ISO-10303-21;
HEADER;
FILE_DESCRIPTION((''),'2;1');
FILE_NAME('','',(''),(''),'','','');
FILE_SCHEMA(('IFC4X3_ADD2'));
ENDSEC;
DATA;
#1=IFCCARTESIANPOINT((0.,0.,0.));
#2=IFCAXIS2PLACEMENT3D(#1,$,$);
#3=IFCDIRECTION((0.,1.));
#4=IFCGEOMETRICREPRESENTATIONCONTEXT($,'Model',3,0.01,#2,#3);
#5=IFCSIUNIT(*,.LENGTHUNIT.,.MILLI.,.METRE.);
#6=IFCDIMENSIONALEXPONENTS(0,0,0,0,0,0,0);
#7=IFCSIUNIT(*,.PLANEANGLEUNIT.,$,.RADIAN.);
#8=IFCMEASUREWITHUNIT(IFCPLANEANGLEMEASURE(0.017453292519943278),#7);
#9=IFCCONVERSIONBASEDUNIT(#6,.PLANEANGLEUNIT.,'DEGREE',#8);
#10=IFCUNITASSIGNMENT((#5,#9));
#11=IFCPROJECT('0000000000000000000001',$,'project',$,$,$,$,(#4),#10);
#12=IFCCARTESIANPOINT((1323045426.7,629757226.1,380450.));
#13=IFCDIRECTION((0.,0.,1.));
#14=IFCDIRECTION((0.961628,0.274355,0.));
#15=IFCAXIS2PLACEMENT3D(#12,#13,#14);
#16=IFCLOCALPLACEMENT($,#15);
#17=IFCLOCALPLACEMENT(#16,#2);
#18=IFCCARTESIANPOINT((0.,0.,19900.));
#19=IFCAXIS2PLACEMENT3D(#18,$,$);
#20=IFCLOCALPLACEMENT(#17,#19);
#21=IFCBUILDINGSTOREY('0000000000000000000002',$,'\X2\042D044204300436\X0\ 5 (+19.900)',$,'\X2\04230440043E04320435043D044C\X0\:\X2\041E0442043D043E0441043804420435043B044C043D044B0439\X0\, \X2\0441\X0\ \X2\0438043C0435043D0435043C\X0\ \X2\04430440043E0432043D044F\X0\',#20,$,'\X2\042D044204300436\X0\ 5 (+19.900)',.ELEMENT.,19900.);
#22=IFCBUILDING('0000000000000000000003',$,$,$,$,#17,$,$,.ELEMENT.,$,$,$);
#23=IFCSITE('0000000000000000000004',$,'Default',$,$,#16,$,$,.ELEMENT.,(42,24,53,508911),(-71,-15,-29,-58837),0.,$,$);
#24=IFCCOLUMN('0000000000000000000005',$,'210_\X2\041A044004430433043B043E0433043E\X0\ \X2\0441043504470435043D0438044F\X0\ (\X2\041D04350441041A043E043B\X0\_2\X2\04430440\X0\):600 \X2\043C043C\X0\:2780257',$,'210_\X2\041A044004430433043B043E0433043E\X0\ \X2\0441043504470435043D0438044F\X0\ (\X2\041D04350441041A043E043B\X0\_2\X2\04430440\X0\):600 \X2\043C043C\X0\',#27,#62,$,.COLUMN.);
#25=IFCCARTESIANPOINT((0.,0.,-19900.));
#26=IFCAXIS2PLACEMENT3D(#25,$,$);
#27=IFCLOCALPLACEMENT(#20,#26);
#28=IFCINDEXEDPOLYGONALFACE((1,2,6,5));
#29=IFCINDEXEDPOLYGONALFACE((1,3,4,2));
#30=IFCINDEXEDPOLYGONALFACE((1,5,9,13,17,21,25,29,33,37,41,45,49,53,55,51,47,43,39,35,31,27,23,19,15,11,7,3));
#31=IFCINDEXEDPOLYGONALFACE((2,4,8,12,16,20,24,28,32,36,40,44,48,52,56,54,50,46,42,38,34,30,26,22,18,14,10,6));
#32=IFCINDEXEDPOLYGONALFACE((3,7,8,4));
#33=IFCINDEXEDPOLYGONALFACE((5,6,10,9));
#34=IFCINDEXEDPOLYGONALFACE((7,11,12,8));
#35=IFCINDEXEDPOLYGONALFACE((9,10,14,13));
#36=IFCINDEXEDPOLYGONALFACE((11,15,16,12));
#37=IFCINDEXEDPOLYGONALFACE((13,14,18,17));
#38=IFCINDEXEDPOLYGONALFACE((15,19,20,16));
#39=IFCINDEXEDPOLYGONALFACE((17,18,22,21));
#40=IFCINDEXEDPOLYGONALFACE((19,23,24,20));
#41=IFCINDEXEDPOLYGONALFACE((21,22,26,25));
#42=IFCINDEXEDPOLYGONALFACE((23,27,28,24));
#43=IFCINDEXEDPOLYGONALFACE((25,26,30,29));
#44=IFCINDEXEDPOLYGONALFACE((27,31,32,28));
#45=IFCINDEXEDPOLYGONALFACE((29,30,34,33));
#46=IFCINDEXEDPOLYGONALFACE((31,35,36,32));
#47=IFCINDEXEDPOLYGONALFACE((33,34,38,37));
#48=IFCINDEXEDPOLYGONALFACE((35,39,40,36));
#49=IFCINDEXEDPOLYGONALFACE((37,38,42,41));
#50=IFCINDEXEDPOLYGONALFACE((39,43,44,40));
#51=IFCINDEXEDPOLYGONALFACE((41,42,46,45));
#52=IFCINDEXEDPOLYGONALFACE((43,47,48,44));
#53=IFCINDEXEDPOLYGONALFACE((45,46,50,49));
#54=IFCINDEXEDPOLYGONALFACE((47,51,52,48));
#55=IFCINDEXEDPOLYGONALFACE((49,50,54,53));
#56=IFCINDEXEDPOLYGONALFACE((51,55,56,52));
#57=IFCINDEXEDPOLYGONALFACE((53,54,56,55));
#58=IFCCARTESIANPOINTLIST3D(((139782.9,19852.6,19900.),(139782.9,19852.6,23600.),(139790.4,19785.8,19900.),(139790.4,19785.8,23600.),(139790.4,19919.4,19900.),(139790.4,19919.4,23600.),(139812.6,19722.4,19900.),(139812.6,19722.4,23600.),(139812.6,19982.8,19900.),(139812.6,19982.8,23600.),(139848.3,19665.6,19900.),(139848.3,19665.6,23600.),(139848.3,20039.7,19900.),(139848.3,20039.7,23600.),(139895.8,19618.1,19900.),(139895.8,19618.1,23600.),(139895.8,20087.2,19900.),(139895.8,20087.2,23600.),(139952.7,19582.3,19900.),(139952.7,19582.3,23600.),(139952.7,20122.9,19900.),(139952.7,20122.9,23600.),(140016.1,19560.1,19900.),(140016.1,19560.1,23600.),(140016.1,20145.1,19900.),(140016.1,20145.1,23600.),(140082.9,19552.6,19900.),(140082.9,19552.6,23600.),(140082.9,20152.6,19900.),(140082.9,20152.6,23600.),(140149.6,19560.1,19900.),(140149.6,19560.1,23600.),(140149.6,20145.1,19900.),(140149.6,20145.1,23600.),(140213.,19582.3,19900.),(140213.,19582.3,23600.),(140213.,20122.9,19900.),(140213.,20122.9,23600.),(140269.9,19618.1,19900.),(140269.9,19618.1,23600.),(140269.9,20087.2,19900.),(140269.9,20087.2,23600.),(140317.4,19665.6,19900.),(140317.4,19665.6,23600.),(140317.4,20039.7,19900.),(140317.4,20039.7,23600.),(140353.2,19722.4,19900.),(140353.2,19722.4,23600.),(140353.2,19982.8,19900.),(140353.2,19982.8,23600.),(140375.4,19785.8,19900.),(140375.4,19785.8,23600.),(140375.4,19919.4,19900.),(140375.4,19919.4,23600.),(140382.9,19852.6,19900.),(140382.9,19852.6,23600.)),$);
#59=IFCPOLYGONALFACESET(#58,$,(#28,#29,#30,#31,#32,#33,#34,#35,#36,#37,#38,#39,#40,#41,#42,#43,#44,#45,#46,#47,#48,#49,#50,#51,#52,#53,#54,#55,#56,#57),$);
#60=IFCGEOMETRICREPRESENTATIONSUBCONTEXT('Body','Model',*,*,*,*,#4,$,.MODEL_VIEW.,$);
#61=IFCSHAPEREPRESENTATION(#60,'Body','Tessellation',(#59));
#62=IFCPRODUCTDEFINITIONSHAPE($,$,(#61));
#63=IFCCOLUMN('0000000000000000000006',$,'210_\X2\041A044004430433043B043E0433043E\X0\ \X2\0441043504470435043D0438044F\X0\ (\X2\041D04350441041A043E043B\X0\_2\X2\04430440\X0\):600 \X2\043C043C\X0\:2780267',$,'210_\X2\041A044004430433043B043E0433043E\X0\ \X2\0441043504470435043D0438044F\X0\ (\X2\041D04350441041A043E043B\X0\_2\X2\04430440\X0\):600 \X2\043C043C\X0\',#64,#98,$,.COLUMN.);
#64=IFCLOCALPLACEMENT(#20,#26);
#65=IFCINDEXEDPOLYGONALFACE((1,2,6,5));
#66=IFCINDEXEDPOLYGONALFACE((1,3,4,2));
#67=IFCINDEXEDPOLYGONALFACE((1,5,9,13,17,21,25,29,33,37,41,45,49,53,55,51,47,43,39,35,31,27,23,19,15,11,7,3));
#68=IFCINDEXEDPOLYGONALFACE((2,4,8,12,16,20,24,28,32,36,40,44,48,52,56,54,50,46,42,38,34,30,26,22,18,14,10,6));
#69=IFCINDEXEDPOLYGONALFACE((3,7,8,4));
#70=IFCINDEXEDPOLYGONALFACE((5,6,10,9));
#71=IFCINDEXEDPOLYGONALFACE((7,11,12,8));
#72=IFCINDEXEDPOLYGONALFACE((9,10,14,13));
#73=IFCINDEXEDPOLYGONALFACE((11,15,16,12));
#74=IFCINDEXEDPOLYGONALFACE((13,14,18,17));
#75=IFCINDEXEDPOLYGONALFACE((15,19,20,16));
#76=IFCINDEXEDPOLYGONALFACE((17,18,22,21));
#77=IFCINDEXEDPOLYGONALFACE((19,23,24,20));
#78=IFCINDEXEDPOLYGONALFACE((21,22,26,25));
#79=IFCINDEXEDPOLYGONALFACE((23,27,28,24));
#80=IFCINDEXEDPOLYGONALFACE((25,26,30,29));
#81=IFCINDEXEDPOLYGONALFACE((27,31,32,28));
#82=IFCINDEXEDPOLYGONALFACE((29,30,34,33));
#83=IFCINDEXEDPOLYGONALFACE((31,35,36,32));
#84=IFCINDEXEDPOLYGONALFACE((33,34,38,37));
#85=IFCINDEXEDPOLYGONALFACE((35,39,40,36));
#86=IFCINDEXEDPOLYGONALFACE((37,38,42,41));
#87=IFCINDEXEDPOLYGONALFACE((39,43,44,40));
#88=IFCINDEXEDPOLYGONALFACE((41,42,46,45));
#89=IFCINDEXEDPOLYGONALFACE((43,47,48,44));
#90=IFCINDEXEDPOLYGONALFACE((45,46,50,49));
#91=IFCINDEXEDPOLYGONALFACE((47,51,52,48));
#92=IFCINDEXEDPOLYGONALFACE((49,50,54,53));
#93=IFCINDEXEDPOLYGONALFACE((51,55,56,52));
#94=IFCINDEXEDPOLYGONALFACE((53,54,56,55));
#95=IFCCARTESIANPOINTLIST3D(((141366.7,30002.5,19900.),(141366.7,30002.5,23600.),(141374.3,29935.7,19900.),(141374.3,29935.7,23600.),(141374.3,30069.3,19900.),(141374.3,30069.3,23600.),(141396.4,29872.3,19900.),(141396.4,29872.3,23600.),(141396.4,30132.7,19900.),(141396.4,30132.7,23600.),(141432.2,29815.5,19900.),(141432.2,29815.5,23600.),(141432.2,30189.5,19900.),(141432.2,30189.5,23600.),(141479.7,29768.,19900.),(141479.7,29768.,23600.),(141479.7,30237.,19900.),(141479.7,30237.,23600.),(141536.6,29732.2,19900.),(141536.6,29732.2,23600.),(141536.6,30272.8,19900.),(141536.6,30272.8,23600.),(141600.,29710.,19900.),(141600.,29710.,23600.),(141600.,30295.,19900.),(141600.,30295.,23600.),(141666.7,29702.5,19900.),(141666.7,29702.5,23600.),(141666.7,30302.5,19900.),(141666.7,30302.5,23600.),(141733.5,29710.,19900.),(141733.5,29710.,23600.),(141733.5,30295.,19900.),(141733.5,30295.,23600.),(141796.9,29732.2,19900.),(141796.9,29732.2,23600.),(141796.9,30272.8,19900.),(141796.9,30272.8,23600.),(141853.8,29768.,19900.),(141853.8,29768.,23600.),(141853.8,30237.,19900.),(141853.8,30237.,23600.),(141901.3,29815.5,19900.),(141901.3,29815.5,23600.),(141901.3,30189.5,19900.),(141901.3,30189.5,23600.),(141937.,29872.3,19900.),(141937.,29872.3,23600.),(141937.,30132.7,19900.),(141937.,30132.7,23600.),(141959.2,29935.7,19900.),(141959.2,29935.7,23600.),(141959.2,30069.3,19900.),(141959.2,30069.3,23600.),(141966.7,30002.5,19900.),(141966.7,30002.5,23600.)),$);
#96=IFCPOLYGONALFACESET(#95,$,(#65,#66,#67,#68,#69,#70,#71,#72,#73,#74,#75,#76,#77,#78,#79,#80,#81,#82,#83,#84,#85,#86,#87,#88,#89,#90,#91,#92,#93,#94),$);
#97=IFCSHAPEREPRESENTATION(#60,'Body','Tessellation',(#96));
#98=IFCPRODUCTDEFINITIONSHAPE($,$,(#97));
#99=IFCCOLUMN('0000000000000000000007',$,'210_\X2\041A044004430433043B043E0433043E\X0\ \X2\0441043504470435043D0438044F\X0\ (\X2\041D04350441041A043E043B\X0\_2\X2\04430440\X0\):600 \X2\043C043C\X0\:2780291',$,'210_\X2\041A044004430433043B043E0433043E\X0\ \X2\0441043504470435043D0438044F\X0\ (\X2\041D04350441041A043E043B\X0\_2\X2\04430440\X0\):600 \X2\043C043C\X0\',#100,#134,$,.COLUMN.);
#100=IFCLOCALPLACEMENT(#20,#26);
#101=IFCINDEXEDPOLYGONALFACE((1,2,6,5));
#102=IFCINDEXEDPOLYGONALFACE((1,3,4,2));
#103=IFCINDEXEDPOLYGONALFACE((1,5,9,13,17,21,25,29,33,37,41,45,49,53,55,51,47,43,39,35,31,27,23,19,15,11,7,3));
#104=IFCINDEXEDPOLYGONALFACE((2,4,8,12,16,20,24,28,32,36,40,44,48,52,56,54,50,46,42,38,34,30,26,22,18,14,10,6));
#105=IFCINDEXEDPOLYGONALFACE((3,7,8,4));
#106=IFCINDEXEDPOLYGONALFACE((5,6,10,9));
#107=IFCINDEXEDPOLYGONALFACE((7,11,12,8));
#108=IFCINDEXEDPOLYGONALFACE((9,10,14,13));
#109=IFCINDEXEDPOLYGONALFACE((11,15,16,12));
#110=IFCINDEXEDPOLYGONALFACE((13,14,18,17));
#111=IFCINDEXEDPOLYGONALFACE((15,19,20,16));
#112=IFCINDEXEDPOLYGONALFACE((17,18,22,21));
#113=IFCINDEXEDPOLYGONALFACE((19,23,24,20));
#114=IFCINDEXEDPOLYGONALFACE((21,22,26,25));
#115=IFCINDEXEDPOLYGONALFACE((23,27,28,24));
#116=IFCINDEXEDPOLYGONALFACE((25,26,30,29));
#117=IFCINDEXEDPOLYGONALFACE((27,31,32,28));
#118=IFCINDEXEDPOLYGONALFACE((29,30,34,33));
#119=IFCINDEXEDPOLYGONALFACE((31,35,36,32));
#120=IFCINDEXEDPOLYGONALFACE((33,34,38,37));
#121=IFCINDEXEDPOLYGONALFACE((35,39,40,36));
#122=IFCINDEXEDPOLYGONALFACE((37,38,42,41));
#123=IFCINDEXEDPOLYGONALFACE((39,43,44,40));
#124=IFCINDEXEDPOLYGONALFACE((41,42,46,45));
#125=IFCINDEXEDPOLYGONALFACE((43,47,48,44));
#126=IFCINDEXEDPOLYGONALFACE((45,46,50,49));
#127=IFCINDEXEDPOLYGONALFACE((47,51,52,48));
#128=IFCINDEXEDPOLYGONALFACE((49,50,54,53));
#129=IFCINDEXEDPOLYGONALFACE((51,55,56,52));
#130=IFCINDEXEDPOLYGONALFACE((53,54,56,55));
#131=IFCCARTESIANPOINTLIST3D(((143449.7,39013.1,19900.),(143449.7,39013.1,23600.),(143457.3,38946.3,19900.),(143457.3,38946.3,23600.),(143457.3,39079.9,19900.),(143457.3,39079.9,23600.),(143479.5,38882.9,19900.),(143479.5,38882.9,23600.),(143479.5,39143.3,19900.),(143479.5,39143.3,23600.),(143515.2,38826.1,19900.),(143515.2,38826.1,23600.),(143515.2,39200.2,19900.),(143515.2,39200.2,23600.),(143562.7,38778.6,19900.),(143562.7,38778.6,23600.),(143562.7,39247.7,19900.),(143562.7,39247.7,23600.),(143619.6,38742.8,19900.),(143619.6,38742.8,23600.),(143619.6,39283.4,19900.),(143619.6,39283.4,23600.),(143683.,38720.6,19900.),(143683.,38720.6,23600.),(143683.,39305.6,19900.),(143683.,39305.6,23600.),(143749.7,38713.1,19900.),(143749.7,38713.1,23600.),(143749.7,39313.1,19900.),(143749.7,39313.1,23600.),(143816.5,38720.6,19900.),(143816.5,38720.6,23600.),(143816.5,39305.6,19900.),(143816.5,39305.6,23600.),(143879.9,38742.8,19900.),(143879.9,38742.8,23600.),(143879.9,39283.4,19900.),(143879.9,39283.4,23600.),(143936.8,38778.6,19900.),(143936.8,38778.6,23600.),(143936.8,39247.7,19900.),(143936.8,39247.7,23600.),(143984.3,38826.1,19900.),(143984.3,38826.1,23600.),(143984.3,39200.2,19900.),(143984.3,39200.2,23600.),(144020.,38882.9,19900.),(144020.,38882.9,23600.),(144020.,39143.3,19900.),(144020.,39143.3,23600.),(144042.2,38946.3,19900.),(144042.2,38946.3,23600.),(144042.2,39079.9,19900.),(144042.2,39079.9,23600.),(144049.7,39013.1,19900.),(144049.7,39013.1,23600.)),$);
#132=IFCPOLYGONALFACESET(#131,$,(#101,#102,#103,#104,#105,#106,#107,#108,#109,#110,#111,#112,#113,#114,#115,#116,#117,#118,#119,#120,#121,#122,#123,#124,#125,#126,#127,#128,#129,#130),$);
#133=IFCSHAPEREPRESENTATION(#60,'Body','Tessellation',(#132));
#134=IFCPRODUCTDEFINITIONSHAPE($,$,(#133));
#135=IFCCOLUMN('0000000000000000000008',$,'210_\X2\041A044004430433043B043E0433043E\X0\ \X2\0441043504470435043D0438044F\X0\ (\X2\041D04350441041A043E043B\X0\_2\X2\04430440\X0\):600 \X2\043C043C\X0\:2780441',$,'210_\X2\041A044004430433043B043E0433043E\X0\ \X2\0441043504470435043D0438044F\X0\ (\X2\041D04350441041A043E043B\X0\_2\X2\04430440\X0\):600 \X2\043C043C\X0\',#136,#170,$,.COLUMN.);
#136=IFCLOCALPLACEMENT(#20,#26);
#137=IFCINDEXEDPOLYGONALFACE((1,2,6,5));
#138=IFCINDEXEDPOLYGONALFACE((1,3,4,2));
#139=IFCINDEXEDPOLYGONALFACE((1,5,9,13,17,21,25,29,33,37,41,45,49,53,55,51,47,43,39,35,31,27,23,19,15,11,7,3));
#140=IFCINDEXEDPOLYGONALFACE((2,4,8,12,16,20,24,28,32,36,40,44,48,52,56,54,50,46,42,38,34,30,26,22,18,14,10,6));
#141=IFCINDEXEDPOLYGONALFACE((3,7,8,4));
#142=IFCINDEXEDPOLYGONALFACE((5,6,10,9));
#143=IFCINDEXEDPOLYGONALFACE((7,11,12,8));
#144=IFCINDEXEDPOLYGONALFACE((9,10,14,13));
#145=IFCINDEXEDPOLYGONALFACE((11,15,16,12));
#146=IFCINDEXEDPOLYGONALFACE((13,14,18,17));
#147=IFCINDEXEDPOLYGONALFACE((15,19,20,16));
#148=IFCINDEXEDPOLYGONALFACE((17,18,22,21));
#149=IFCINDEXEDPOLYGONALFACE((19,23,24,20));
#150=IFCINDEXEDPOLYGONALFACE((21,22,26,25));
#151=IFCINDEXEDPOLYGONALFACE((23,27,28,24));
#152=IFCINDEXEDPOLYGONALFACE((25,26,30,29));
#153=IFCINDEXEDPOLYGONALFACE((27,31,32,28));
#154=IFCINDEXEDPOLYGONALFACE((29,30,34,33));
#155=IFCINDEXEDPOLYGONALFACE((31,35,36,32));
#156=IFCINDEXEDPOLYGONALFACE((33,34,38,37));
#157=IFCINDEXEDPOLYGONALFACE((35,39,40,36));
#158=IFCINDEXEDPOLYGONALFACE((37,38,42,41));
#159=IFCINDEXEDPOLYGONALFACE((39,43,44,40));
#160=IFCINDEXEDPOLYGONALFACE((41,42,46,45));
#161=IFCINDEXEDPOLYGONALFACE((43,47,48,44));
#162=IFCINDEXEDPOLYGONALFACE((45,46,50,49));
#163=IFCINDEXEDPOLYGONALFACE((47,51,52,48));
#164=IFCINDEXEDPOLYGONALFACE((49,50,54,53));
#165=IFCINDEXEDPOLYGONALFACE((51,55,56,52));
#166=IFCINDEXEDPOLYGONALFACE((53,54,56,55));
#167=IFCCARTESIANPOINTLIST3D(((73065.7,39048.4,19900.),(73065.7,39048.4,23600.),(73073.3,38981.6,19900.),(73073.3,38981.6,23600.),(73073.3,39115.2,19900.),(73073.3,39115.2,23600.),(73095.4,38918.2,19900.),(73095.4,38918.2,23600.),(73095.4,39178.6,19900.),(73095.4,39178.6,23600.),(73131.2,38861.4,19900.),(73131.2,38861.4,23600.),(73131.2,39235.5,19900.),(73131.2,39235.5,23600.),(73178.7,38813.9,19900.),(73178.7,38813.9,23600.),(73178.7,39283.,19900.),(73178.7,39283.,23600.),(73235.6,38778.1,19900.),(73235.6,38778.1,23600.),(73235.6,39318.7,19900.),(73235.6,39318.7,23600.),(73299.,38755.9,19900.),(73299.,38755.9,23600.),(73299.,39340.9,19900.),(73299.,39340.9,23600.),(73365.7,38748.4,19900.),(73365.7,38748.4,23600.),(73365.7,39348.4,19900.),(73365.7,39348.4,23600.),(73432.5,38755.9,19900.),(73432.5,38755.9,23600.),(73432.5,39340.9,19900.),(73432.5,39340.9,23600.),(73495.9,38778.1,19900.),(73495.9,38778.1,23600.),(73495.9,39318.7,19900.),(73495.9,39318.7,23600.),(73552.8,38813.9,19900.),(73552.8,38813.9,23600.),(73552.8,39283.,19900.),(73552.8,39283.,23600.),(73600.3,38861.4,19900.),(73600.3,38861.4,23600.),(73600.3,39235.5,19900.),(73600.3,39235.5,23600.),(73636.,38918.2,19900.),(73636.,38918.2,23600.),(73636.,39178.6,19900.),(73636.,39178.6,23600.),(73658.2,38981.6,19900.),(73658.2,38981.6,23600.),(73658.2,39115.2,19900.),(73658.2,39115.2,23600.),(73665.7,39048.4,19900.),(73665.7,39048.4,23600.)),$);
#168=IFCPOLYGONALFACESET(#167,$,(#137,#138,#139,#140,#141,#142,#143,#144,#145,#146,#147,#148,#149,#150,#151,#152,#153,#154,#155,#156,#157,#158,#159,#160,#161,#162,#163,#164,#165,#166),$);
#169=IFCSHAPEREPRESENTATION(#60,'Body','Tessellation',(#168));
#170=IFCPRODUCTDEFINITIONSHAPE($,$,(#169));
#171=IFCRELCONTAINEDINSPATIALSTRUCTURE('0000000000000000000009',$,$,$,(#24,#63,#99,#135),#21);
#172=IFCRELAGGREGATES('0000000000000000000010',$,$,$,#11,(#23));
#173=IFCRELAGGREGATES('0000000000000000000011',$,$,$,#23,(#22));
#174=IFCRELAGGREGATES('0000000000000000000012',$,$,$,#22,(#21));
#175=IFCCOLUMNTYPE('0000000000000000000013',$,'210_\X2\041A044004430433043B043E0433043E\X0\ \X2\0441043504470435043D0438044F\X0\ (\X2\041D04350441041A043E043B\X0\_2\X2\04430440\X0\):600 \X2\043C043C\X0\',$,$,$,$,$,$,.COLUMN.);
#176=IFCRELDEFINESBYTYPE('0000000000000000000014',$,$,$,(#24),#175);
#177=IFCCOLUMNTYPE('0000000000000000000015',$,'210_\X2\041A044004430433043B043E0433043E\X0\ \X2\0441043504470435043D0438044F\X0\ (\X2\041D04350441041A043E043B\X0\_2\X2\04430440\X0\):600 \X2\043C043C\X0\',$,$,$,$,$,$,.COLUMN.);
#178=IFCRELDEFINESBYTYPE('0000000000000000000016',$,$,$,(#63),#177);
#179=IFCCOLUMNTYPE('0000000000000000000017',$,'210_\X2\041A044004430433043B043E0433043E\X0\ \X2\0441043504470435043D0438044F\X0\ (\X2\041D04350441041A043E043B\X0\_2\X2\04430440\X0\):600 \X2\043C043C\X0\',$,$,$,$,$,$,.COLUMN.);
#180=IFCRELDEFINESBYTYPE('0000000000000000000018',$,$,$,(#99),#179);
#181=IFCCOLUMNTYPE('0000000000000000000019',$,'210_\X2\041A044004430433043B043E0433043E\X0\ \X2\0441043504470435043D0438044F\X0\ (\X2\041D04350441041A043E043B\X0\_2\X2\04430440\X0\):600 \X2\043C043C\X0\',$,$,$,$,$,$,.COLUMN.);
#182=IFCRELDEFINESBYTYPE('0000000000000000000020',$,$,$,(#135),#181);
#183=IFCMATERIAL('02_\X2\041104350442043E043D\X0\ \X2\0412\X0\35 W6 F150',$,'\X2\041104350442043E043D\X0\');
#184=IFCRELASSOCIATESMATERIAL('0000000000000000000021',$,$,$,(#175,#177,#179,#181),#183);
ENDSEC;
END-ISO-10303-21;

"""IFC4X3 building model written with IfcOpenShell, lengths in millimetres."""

from ifc_helpers import new_model, entity, si_unit, converted_unit, direction, frame, origin, origin_2d_with_axis, place, context, subcontext, project, spatial, circle, extrude, source, transform, mapped, material, material_profile, profile_set, type_object, type_shapes, element, save


model = new_model("IFC4X3")

# Units and contexts
model_context = context("Model", 3, precision=0.01, world=origin(), true_north=direction((0.0, 1.0)))
body_context = subcontext(model_context, "Body", "Model", "MODEL_VIEW")
ifc_project = project(units=[si_unit("LENGTHUNIT", "METRE", prefix="MILLI"), converted_unit("PLANEANGLEUNIT", "DEGREE", entity("IfcPlaneAngleMeasure", 0.017453292519943278), si_unit("PLANEANGLEUNIT", "RADIAN"), dimensions=[0, 0, 0, 0, 0, 0, 0])], contexts=[model_context])

# Site, building, storey
site_placement = place(None, frame((1323045426.7, 629757226.1, 380450.0), z_axis=(0.0, 0.0, 1.0), x_axis=(0.961628, 0.274355, 0.0)))
site = spatial("IfcSite", under=ifc_project, at=site_placement, Name="Default", CompositionType="ELEMENT", RefLatitude=(42, 24, 53, 508911), RefLongitude=(-71, -15, -29, -58837), RefElevation=0.0)
building_placement = place(site_placement, origin())
building = spatial("IfcBuilding", under=site, at=building_placement, CompositionType="ELEMENT")
storey_placement = place(building_placement, frame((0.0, 0.0, 19900.0)))
storey = spatial("IfcBuildingStorey", under=building, at=storey_placement, Name="Этаж 5 (+19.900)", ObjectType="Уровень:Относительный, с именем уровня", LongName="Этаж 5 (+19.900)", CompositionType="ELEMENT", Elevation=19900.0)

# Columns
ifc_material = material(Name="02_Бетон В35 W6 F150", Category="Бетон")
ifc_material_profile = material_profile(ifc_material, circle(Radius=300.0, at=origin_2d_with_axis()), Name="600 мм")
ifc_profile_set = profile_set([ifc_material_profile], Name="600 мм")
column_type_1 = type_object("IfcColumnType", Name="210_Круглого сечения (НесКол_2ур):600 мм", PredefinedType="COLUMN", material=ifc_profile_set)
shared_shape_1 = source(origin(), body_context, "Body", "SweptSolid", [
    extrude(circle(Radius=300.0, at=origin_2d_with_axis()), frame((140082.9, 19852.6, 19900.0)), (0.0, 0.0, 1.0), 3700.0),
])
type_shapes(column_type_1, [shared_shape_1])
column_1_placement = place(storey_placement, frame((0.0, 0.0, -19900.0)))
element("IfcColumn", 1, at=column_1_placement, inside=storey, type_object=column_type_1, Name="210_Круглого сечения (НесКол_2ур):600 мм:2780257", ObjectType="210_Круглого сечения (НесКол_2ур):600 мм", PredefinedType="COLUMN", context=body_context, shape_type="MappedRepresentation", body=[
    mapped(shared_shape_1, transform((0.0, 0.0, 0.0), scale=1.0)),
])
column_type_2 = type_object("IfcColumnType", Name="210_Круглого сечения (НесКол_2ур):600 мм", PredefinedType="COLUMN", material=ifc_profile_set)
shared_shape_2 = source(origin(), body_context, "Body", "SweptSolid", [
    extrude(circle(Radius=300.0, at=origin_2d_with_axis()), frame((141666.7, 30002.5, 19900.0)), (0.0, 0.0, 1.0), 3700.0),
])
type_shapes(column_type_2, [shared_shape_2])
column_2_placement = place(storey_placement, frame((0.0, 0.0, -19900.0)))
element("IfcColumn", 2, at=column_2_placement, inside=storey, type_object=column_type_2, Name="210_Круглого сечения (НесКол_2ур):600 мм:2780267", ObjectType="210_Круглого сечения (НесКол_2ур):600 мм", PredefinedType="COLUMN", context=body_context, shape_type="MappedRepresentation", body=[
    mapped(shared_shape_2, transform((0.0, 0.0, 0.0), scale=1.0)),
])
column_type_3 = type_object("IfcColumnType", Name="210_Круглого сечения (НесКол_2ур):600 мм", PredefinedType="COLUMN", material=ifc_profile_set)
shared_shape_3 = source(origin(), body_context, "Body", "SweptSolid", [
    extrude(circle(Radius=300.0, at=origin_2d_with_axis()), frame((143749.7, 39013.1, 19900.0)), (0.0, 0.0, 1.0), 3700.0),
])
type_shapes(column_type_3, [shared_shape_3])
column_3_placement = place(storey_placement, frame((0.0, 0.0, -19900.0)))
element("IfcColumn", 3, at=column_3_placement, inside=storey, type_object=column_type_3, Name="210_Круглого сечения (НесКол_2ур):600 мм:2780291", ObjectType="210_Круглого сечения (НесКол_2ур):600 мм", PredefinedType="COLUMN", context=body_context, shape_type="MappedRepresentation", body=[
    mapped(shared_shape_3, transform((0.0, 0.0, 0.0), scale=1.0)),
])
column_type_4 = type_object("IfcColumnType", Name="210_Круглого сечения (НесКол_2ур):600 мм", PredefinedType="COLUMN", material=ifc_profile_set)
shared_shape_4 = source(origin(), body_context, "Body", "SweptSolid", [
    extrude(circle(Radius=300.0, at=origin_2d_with_axis()), frame((73365.7, 39048.4, 19900.0)), (0.0, 0.0, 1.0), 3700.0),
])
type_shapes(column_type_4, [shared_shape_4])
column_4_placement = place(storey_placement, frame((0.0, 0.0, -19900.0)))
element("IfcColumn", 4, at=column_4_placement, inside=storey, type_object=column_type_4, Name="210_Круглого сечения (НесКол_2ур):600 мм:2780441", ObjectType="210_Круглого сечения (НесКол_2ур):600 мм", PredefinedType="COLUMN", context=body_context, shape_type="MappedRepresentation", body=[
    mapped(shared_shape_4, transform((0.0, 0.0, 0.0), scale=1.0)),
])

save(model, "model.ifc")
